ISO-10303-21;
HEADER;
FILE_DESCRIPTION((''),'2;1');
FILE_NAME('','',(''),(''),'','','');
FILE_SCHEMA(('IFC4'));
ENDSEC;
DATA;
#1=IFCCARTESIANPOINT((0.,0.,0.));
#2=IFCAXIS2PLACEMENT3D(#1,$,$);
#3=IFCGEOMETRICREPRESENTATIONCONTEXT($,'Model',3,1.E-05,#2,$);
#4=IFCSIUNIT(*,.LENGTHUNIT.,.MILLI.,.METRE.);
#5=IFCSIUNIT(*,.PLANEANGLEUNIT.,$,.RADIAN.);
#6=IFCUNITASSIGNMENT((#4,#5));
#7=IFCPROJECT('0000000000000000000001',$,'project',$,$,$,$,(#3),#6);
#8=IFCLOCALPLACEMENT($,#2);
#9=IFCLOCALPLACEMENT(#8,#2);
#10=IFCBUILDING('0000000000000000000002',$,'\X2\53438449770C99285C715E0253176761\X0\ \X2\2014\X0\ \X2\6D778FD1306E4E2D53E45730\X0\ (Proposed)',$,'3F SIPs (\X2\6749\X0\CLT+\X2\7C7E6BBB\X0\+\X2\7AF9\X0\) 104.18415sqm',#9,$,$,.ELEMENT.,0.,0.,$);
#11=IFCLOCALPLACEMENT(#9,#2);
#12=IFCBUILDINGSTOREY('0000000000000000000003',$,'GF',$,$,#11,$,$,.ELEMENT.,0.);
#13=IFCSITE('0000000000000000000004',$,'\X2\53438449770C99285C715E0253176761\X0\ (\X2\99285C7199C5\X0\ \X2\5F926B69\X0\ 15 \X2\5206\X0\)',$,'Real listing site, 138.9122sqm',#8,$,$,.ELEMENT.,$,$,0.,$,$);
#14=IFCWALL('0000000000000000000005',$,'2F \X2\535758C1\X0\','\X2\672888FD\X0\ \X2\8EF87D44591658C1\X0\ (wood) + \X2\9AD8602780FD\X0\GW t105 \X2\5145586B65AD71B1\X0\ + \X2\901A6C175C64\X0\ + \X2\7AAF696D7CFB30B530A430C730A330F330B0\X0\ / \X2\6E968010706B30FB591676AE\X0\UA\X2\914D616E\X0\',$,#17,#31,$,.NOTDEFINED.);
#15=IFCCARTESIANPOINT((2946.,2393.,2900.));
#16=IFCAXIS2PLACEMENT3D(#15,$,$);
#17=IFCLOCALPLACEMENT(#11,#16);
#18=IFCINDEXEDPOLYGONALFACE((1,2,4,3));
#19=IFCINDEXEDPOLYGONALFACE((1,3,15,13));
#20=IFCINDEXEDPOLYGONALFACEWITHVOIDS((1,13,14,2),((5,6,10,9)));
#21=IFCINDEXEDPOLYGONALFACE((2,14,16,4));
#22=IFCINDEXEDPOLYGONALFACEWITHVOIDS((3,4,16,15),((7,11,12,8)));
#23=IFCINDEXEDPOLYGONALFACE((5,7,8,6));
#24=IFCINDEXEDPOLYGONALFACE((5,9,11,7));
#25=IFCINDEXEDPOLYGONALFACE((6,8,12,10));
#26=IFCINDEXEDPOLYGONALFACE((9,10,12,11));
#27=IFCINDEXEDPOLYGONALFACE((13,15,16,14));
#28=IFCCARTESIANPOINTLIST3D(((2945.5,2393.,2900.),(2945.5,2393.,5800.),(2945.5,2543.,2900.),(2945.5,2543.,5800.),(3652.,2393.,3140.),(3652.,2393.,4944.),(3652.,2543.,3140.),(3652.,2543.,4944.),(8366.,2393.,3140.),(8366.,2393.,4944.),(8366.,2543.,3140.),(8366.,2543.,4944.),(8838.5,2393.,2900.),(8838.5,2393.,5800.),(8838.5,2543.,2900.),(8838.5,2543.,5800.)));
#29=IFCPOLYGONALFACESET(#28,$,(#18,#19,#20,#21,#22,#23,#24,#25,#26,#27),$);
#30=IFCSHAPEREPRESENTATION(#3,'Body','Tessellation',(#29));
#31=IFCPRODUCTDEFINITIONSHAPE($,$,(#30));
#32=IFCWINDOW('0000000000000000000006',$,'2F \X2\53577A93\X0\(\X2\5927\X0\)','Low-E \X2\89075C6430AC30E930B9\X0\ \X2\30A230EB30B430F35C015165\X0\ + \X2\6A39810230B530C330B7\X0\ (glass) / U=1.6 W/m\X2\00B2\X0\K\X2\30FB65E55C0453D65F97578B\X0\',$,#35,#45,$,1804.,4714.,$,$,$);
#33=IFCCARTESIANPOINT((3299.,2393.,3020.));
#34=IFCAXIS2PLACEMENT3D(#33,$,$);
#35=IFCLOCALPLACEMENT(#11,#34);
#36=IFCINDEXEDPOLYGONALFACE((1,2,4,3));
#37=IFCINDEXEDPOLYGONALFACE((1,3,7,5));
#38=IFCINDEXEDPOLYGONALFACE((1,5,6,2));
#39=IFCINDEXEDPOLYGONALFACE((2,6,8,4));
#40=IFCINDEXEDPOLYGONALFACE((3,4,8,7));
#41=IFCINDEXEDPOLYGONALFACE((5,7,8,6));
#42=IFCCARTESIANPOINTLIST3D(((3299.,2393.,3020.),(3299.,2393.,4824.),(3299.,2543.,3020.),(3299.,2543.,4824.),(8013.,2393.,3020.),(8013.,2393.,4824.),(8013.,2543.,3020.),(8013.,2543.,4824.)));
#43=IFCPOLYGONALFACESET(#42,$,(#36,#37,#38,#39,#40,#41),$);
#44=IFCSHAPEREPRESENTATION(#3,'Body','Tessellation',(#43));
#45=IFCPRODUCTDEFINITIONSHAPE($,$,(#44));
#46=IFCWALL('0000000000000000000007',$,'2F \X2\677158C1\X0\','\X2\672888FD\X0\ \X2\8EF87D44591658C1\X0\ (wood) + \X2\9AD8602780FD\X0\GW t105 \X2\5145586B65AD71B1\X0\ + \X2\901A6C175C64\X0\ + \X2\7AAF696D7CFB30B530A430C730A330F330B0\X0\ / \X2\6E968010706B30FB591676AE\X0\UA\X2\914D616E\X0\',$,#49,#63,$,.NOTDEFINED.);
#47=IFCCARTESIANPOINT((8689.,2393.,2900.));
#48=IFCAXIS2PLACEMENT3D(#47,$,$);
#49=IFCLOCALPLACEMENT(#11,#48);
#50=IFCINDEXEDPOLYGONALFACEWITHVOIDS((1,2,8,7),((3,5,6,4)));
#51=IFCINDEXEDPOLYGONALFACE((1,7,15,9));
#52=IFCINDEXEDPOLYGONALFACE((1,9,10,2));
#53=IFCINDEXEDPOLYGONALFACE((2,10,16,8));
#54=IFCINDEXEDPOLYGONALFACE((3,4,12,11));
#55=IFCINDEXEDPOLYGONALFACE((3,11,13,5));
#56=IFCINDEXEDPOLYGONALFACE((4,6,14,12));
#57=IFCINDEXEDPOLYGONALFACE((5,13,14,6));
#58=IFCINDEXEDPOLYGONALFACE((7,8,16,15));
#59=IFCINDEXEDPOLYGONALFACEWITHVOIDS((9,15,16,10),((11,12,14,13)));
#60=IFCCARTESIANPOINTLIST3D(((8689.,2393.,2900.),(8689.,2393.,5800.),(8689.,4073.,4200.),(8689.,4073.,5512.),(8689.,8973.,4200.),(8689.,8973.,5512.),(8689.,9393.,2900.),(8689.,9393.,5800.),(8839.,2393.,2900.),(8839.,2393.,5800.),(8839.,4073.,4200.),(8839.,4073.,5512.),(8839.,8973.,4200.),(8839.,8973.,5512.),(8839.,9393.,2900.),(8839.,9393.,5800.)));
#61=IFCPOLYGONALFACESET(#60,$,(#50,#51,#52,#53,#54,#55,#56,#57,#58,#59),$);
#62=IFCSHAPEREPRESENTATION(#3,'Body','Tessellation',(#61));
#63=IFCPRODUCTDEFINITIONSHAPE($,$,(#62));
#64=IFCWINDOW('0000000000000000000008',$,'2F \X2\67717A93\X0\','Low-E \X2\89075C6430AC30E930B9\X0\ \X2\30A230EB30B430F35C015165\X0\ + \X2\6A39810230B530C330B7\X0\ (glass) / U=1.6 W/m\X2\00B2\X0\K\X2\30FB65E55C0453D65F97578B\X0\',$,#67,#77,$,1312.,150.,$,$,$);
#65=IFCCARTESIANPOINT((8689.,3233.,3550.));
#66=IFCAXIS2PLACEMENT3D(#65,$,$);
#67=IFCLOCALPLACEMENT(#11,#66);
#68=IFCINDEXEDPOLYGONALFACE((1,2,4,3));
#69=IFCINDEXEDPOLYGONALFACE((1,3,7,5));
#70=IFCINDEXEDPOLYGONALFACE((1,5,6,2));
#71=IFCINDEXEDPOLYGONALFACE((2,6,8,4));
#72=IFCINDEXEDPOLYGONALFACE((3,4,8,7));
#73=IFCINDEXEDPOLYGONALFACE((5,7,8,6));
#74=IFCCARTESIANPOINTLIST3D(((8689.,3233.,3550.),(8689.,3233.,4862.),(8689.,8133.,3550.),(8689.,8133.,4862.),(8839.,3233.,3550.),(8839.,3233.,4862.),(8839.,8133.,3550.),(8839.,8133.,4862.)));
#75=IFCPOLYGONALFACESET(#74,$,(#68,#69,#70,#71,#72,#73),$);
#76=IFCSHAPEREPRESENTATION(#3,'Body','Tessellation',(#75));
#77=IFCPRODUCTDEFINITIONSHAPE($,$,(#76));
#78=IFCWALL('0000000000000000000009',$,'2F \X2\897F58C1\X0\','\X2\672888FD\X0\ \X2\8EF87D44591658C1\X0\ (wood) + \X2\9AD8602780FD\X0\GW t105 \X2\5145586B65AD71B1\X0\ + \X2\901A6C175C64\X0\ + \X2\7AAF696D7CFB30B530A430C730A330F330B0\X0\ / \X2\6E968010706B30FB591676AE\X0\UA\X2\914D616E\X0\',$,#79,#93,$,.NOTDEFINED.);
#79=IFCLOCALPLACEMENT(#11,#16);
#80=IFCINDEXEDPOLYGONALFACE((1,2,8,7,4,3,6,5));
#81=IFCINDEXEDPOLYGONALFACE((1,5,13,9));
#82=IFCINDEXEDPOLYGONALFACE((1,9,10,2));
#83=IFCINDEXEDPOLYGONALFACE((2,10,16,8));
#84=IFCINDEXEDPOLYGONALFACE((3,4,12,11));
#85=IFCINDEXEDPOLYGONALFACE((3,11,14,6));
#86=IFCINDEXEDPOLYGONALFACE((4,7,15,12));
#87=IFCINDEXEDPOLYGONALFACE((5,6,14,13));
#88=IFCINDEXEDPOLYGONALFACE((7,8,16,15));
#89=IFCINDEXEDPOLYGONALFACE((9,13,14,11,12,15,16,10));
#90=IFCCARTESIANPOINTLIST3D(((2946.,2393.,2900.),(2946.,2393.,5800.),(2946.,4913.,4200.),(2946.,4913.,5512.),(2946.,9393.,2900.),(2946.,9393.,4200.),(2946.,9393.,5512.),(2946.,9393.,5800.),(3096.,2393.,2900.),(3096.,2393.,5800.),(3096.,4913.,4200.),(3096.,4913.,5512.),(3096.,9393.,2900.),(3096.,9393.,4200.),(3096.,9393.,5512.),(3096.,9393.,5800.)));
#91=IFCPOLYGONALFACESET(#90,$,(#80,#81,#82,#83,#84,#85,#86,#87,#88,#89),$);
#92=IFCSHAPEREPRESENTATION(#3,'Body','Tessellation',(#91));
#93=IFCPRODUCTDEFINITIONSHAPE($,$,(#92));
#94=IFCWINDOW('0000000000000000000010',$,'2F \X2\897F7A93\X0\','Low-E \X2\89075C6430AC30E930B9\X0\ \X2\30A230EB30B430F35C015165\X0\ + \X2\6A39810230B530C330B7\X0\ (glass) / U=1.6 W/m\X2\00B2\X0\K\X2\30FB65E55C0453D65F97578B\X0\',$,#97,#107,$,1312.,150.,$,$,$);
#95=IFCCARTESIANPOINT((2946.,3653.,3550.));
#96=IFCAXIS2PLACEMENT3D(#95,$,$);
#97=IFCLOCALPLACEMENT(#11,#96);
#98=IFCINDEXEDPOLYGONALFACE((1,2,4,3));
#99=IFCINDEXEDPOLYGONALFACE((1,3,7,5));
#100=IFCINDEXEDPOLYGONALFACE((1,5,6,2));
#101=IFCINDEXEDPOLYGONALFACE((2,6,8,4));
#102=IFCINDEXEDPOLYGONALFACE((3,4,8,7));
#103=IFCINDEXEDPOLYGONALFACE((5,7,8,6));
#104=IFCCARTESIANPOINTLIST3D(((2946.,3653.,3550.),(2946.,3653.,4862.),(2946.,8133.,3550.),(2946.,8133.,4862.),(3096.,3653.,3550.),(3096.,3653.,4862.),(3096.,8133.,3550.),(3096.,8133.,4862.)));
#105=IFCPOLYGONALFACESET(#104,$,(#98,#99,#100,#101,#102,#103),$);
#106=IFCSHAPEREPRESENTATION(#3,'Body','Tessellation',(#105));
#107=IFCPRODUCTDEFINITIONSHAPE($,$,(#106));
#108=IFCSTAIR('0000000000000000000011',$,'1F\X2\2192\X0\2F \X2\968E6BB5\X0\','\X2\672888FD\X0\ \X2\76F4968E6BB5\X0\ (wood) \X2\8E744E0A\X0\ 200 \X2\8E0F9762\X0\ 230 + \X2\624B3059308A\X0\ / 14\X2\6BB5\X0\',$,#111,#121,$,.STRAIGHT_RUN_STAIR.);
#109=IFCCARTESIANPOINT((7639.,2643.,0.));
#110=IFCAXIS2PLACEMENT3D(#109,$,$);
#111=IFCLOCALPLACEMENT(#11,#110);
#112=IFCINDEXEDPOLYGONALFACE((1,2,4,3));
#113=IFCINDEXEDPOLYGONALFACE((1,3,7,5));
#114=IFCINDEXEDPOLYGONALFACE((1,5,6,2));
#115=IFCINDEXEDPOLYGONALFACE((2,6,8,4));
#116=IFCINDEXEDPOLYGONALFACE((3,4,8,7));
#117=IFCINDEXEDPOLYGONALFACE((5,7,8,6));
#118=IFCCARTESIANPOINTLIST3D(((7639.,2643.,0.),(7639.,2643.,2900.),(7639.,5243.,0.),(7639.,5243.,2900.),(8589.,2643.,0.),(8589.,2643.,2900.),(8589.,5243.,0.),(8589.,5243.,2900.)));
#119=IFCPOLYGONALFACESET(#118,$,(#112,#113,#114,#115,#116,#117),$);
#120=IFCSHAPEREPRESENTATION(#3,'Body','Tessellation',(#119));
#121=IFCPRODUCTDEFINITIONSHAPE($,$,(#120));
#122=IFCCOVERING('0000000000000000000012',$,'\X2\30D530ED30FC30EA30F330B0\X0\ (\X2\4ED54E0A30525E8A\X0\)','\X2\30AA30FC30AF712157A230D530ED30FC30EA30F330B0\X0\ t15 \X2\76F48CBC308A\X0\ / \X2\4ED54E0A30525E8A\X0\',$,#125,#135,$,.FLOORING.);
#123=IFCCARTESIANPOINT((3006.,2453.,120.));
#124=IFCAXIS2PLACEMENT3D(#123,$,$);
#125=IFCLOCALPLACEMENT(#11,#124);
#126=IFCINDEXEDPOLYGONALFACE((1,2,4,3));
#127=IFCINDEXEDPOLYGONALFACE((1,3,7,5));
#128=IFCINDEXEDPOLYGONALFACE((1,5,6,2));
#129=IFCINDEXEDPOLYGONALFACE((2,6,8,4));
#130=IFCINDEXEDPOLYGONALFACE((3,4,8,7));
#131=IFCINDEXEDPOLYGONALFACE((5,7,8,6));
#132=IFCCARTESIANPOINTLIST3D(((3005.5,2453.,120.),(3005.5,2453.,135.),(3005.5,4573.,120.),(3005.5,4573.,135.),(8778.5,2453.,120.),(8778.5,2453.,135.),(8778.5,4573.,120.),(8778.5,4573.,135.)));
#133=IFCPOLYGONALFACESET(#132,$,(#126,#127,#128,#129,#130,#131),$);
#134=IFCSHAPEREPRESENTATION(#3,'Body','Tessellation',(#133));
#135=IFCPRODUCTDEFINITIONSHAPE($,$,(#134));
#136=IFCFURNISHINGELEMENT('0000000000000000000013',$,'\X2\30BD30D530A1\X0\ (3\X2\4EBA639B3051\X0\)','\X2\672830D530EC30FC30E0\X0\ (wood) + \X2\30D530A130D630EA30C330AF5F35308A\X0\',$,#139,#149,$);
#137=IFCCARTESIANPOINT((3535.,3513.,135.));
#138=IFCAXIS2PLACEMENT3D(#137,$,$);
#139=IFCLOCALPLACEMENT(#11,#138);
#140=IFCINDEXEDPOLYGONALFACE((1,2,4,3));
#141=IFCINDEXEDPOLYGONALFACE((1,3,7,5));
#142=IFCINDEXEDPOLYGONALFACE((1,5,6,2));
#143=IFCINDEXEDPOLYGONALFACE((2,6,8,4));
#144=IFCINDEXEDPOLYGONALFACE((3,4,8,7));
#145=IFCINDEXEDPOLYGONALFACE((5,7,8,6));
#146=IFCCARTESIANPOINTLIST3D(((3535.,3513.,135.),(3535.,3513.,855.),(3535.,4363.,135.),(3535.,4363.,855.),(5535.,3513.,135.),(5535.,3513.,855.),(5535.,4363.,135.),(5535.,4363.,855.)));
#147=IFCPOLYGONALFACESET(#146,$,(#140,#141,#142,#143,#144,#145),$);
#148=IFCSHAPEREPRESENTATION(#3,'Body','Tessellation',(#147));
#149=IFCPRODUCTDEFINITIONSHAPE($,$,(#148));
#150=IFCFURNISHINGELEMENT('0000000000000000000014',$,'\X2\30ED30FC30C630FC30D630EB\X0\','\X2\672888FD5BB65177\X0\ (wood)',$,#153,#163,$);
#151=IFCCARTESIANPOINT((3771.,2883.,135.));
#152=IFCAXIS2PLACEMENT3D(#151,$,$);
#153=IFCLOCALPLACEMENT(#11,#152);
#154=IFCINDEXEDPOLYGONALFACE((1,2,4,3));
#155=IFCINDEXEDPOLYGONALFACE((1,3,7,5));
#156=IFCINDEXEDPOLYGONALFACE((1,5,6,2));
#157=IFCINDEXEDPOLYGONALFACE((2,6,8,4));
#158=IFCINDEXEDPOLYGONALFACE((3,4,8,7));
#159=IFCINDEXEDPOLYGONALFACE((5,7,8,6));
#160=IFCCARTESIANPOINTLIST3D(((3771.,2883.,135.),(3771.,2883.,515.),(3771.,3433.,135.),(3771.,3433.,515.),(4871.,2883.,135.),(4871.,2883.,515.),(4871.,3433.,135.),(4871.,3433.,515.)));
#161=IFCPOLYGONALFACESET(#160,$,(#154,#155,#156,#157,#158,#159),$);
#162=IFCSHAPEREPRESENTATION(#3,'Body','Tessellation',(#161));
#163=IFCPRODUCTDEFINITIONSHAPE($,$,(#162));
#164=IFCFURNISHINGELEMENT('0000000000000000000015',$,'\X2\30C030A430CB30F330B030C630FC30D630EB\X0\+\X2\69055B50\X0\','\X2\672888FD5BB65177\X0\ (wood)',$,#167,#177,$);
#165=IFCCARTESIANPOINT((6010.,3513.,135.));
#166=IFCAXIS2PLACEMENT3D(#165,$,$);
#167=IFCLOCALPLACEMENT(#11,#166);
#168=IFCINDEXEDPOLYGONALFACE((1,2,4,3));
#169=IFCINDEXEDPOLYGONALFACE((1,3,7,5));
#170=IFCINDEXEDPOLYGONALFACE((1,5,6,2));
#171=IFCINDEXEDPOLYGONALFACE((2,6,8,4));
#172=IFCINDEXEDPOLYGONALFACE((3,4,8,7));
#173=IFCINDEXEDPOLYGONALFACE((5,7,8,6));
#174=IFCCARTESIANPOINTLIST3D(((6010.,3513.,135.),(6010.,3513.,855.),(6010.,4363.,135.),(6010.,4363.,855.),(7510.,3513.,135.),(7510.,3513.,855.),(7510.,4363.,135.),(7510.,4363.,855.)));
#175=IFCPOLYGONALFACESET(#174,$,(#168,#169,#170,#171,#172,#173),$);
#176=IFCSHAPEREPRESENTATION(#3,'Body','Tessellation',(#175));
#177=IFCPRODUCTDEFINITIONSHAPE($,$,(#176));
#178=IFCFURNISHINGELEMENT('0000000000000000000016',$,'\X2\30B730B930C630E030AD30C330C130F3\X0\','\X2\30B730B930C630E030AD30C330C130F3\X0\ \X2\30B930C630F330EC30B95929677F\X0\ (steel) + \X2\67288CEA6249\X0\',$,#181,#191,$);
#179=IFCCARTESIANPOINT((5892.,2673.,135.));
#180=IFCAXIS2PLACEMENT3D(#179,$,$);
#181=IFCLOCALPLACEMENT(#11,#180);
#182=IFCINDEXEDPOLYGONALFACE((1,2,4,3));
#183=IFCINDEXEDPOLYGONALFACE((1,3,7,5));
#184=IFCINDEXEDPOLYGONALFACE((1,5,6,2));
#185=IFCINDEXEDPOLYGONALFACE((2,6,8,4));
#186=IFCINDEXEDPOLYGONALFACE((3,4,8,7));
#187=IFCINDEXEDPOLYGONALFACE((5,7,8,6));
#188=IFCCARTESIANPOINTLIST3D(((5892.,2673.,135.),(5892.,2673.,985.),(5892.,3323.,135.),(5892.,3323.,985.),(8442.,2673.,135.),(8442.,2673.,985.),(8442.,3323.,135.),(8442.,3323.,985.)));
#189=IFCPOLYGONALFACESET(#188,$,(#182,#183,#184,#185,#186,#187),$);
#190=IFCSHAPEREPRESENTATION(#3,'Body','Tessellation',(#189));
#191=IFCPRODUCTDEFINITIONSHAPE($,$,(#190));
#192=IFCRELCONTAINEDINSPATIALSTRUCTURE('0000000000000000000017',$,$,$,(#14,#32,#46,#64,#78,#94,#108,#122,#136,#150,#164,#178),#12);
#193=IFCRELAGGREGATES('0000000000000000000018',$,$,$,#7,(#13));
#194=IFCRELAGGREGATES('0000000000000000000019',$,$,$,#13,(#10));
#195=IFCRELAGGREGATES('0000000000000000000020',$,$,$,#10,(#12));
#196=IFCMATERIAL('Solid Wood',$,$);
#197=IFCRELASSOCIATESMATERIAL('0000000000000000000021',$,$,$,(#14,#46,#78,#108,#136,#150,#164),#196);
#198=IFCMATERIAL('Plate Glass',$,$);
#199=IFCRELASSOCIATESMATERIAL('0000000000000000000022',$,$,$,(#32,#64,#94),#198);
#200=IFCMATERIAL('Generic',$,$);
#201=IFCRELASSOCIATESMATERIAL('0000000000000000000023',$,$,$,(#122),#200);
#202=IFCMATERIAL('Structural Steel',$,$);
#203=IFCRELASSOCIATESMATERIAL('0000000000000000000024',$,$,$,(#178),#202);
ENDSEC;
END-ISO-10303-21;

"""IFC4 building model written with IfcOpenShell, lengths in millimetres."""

from ifc_helpers import new_model, si_unit, frame, frame_2d, origin, place, context, project, spatial, rectangle, extrude, material, element, fill, save


model = new_model("IFC4")

# Units and contexts
model_context = context("Model", 3, precision=1e-05, world=origin())
ifc_project = project(units=[si_unit("LENGTHUNIT", "METRE", prefix="MILLI"), si_unit("PLANEANGLEUNIT", "RADIAN")], contexts=[model_context])

# Site, building, storey
site_placement = place(None, origin())
site = spatial("IfcSite", under=ifc_project, at=site_placement, Name="千葉県館山市北条 (館山駅 徒歩 15 分)", ObjectType="Real listing site, 138.9122sqm", CompositionType="ELEMENT", RefElevation=0.0)
building_placement = place(site_placement, origin())
building = spatial("IfcBuilding", under=site, at=building_placement, Name="千葉県館山市北条 — 海近の中古地 (Proposed)", ObjectType="3F SIPs (杉CLT+籾殻+竹) 104.18415sqm", CompositionType="ELEMENT", ElevationOfRefHeight=0.0, ElevationOfTerrain=0.0)
storey_placement = place(building_placement, origin())
storey = spatial("IfcBuildingStorey", under=building, at=storey_placement, Name="GF", CompositionType="ELEMENT", Elevation=0.0)

# Shared definitions
ifc_material_1 = material(Name="Solid Wood")

# Shared definitions
ifc_material_2 = material(Name="Plate Glass")

# Walls, openings, windows
wall_1_placement = place(storey_placement, frame((2946.0, 2393.0, 2900.0)))
wall_1 = element("IfcWall", 1, at=wall_1_placement, inside=storey, material=ifc_material_1, Name="2F 南壁", Description="木製 軸組外壁 (wood) + 高性能GW t105 充填断熱 + 通気層 + 窯業系サイディング / 準耐火・外皮UA配慮", PredefinedType="NOTDEFINED", context=model_context, shape_type="SweptSolid", body=[
    extrude(rectangle(XDim=5893.0, YDim=150.0, at=frame_2d((2946.0, 75.0))), frame((2946.0, 2393.0, 2900.0)), (0.0, 0.0, 1.0), 2900.0),
])
opening_1_placement = place(storey_placement, frame((3299.0, 2393.0, 3020.0)))
opening_1 = element("IfcOpeningElement", 2, at=opening_1_placement, cuts=wall_1, PredefinedType="NOTDEFINED", context=model_context, shape_type="SweptSolid", body=[
    extrude(rectangle(XDim=4714.0, YDim=150.0, at=frame_2d((2357.0, 75.0))), frame((3299.0, 2393.0, 3020.0)), (0.0, 0.0, 1.0), 1804.0),
])
window_1_placement = place(storey_placement, frame((3299.0, 2393.0, 3020.0)))
window_1 = element("IfcWindow", 3, at=window_1_placement, inside=storey, material=ifc_material_2, Name="2F 南窓(大)", Description="Low-E 複層ガラス アルゴン封入 + 樹脂サッシ (glass) / U=1.6 W/m²K・日射取得型", OverallHeight=1804.0, OverallWidth=4714.0, context=model_context, shape_type="SweptSolid", body=[
    extrude(rectangle(XDim=4714.0, YDim=150.0, at=frame_2d((2357.0, 75.0))), frame((3299.0, 2393.0, 3020.0)), (0.0, 0.0, 1.0), 1804.0),
])
fill(opening_1, window_1)
wall_2_placement = place(storey_placement, frame((8689.0, 2393.0, 2900.0)))
wall_2 = element("IfcWall", 4, at=wall_2_placement, inside=storey, material=ifc_material_1, Name="2F 東壁", Description="木製 軸組外壁 (wood) + 高性能GW t105 充填断熱 + 通気層 + 窯業系サイディング / 準耐火・外皮UA配慮", PredefinedType="NOTDEFINED", context=model_context, shape_type="SweptSolid", body=[
    extrude(rectangle(XDim=150.0, YDim=7000.0, at=frame_2d((75.0, 3500.0))), frame((8689.0, 2393.0, 2900.0)), (0.0, 0.0, 1.0), 2900.0),
])
opening_2_placement = place(storey_placement, frame((8689.0, 3233.0, 3550.0)))
opening_2 = element("IfcOpeningElement", 5, at=opening_2_placement, cuts=wall_2, PredefinedType="NOTDEFINED", context=model_context, shape_type="SweptSolid", body=[
    extrude(rectangle(XDim=150.0, YDim=4900.0, at=frame_2d((75.0, 2450.0))), frame((8689.0, 3233.0, 3550.0)), (0.0, 0.0, 1.0), 1312.0),
])
window_2_placement = place(storey_placement, frame((8689.0, 3233.0, 3550.0)))
window_2 = element("IfcWindow", 6, at=window_2_placement, inside=storey, material=ifc_material_2, Name="2F 東窓", Description="Low-E 複層ガラス アルゴン封入 + 樹脂サッシ (glass) / U=1.6 W/m²K・日射取得型", OverallHeight=1312.0, OverallWidth=150.0, context=model_context, shape_type="SweptSolid", body=[
    extrude(rectangle(XDim=150.0, YDim=4900.0, at=frame_2d((75.0, 2450.0))), frame((8689.0, 3233.0, 3550.0)), (0.0, 0.0, 1.0), 1312.0),
])
fill(opening_2, window_2)
wall_3_placement = place(storey_placement, frame((2946.0, 2393.0, 2900.0)))
wall_3 = element("IfcWall", 7, at=wall_3_placement, inside=storey, material=ifc_material_1, Name="2F 西壁", Description="木製 軸組外壁 (wood) + 高性能GW t105 充填断熱 + 通気層 + 窯業系サイディング / 準耐火・外皮UA配慮", PredefinedType="NOTDEFINED", context=model_context, shape_type="SweptSolid", body=[
    extrude(rectangle(XDim=150.0, YDim=7000.0, at=frame_2d((75.0, 3500.0))), frame((2946.0, 2393.0, 2900.0)), (0.0, 0.0, 1.0), 2900.0),
])
opening_3_placement = place(storey_placement, frame((2946.0, 3653.0, 3550.0)))
opening_3 = element("IfcOpeningElement", 8, at=opening_3_placement, cuts=wall_3, PredefinedType="NOTDEFINED", context=model_context, shape_type="SweptSolid", body=[
    extrude(rectangle(XDim=150.0, YDim=4480.0, at=frame_2d((75.0, 2240.0))), frame((2946.0, 3653.0, 3550.0)), (0.0, 0.0, 1.0), 1312.0),
])
window_3_placement = place(storey_placement, frame((2946.0, 3653.0, 3550.0)))
window_3 = element("IfcWindow", 9, at=window_3_placement, inside=storey, material=ifc_material_2, Name="2F 西窓", Description="Low-E 複層ガラス アルゴン封入 + 樹脂サッシ (glass) / U=1.6 W/m²K・日射取得型", OverallHeight=1312.0, OverallWidth=150.0, context=model_context, shape_type="SweptSolid", body=[
    extrude(rectangle(XDim=150.0, YDim=4480.0, at=frame_2d((75.0, 2240.0))), frame((2946.0, 3653.0, 3550.0)), (0.0, 0.0, 1.0), 1312.0),
])
fill(opening_3, window_3)

# Stair
stair_placement = place(storey_placement, frame((7639.0, 2643.0, 0.0)))
element("IfcStair", 10, at=stair_placement, inside=storey, material=ifc_material_1, Name="1F→2F 階段", Description="木製 直階段 (wood) 蹴上 200 踏面 230 + 手すり / 14段", PredefinedType="STRAIGHT_RUN_STAIR", context=model_context, shape_type="SweptSolid", body=[
    extrude(rectangle(XDim=950.0, YDim=2600.0, at=frame_2d((475.0, 1300.0))), frame((7639.0, 2643.0, 0.0)), (0.0, 0.0, 1.0), 2900.0),
])

# Covering
ifc_material_3 = material(Name="Generic")
covering_placement = place(storey_placement, frame((3006.0, 2453.0, 120.0)))
element("IfcCovering", 11, at=covering_placement, inside=storey, material=ifc_material_3, Name="フローリング (仕上げ床)", Description="オーク無垢フローリング t15 直貼り / 仕上げ床", PredefinedType="FLOORING", context=model_context, shape_type="SweptSolid", body=[
    extrude(rectangle(XDim=5773.0, YDim=2120.0, at=frame_2d((2886.0, 1060.0))), frame((3006.0, 2453.0, 120.0)), (0.0, 0.0, 1.0), 15.0),
])

# Furnishing elements
furnishing_1_placement = place(storey_placement, frame((3535.0, 3513.0, 135.0)))
element("IfcFurnishingElement", 12, at=furnishing_1_placement, inside=storey, material=ifc_material_1, Name="ソファ (3人掛け)", Description="木フレーム (wood) + ファブリック張り", context=model_context, shape_type="SweptSolid", body=[
    extrude(rectangle(XDim=2000.0, YDim=850.0, at=frame_2d((1000.0, 425.0))), frame((3535.0, 3513.0, 135.0)), (0.0, 0.0, 1.0), 720.0),
])
furnishing_2_placement = place(storey_placement, frame((3771.0, 2883.0, 135.0)))
element("IfcFurnishingElement", 13, at=furnishing_2_placement, inside=storey, material=ifc_material_1, Name="ローテーブル", Description="木製家具 (wood)", context=model_context, shape_type="SweptSolid", body=[
    extrude(rectangle(XDim=1100.0, YDim=550.0, at=frame_2d((550.0, 275.0))), frame((3771.0, 2883.0, 135.0)), (0.0, 0.0, 1.0), 380.0),
])
furnishing_3_placement = place(storey_placement, frame((6010.0, 3513.0, 135.0)))
element("IfcFurnishingElement", 14, at=furnishing_3_placement, inside=storey, material=ifc_material_1, Name="ダイニングテーブル+椅子", Description="木製家具 (wood)", context=model_context, shape_type="SweptSolid", body=[
    extrude(rectangle(XDim=1500.0, YDim=850.0, at=frame_2d((750.0, 425.0))), frame((6010.0, 3513.0, 135.0)), (0.0, 0.0, 1.0), 720.0),
])
ifc_material_4 = material(Name="Structural Steel")
furnishing_4_placement = place(storey_placement, frame((5892.0, 2673.0, 135.0)))
element("IfcFurnishingElement", 15, at=furnishing_4_placement, inside=storey, material=ifc_material_4, Name="システムキッチン", Description="システムキッチン ステンレス天板 (steel) + 木質扉", context=model_context, shape_type="SweptSolid", body=[
    extrude(rectangle(XDim=2550.0, YDim=650.0, at=frame_2d((1275.0, 325.0))), frame((5892.0, 2673.0, 135.0)), (0.0, 0.0, 1.0), 850.0),
])

save(model, "model.ifc")
